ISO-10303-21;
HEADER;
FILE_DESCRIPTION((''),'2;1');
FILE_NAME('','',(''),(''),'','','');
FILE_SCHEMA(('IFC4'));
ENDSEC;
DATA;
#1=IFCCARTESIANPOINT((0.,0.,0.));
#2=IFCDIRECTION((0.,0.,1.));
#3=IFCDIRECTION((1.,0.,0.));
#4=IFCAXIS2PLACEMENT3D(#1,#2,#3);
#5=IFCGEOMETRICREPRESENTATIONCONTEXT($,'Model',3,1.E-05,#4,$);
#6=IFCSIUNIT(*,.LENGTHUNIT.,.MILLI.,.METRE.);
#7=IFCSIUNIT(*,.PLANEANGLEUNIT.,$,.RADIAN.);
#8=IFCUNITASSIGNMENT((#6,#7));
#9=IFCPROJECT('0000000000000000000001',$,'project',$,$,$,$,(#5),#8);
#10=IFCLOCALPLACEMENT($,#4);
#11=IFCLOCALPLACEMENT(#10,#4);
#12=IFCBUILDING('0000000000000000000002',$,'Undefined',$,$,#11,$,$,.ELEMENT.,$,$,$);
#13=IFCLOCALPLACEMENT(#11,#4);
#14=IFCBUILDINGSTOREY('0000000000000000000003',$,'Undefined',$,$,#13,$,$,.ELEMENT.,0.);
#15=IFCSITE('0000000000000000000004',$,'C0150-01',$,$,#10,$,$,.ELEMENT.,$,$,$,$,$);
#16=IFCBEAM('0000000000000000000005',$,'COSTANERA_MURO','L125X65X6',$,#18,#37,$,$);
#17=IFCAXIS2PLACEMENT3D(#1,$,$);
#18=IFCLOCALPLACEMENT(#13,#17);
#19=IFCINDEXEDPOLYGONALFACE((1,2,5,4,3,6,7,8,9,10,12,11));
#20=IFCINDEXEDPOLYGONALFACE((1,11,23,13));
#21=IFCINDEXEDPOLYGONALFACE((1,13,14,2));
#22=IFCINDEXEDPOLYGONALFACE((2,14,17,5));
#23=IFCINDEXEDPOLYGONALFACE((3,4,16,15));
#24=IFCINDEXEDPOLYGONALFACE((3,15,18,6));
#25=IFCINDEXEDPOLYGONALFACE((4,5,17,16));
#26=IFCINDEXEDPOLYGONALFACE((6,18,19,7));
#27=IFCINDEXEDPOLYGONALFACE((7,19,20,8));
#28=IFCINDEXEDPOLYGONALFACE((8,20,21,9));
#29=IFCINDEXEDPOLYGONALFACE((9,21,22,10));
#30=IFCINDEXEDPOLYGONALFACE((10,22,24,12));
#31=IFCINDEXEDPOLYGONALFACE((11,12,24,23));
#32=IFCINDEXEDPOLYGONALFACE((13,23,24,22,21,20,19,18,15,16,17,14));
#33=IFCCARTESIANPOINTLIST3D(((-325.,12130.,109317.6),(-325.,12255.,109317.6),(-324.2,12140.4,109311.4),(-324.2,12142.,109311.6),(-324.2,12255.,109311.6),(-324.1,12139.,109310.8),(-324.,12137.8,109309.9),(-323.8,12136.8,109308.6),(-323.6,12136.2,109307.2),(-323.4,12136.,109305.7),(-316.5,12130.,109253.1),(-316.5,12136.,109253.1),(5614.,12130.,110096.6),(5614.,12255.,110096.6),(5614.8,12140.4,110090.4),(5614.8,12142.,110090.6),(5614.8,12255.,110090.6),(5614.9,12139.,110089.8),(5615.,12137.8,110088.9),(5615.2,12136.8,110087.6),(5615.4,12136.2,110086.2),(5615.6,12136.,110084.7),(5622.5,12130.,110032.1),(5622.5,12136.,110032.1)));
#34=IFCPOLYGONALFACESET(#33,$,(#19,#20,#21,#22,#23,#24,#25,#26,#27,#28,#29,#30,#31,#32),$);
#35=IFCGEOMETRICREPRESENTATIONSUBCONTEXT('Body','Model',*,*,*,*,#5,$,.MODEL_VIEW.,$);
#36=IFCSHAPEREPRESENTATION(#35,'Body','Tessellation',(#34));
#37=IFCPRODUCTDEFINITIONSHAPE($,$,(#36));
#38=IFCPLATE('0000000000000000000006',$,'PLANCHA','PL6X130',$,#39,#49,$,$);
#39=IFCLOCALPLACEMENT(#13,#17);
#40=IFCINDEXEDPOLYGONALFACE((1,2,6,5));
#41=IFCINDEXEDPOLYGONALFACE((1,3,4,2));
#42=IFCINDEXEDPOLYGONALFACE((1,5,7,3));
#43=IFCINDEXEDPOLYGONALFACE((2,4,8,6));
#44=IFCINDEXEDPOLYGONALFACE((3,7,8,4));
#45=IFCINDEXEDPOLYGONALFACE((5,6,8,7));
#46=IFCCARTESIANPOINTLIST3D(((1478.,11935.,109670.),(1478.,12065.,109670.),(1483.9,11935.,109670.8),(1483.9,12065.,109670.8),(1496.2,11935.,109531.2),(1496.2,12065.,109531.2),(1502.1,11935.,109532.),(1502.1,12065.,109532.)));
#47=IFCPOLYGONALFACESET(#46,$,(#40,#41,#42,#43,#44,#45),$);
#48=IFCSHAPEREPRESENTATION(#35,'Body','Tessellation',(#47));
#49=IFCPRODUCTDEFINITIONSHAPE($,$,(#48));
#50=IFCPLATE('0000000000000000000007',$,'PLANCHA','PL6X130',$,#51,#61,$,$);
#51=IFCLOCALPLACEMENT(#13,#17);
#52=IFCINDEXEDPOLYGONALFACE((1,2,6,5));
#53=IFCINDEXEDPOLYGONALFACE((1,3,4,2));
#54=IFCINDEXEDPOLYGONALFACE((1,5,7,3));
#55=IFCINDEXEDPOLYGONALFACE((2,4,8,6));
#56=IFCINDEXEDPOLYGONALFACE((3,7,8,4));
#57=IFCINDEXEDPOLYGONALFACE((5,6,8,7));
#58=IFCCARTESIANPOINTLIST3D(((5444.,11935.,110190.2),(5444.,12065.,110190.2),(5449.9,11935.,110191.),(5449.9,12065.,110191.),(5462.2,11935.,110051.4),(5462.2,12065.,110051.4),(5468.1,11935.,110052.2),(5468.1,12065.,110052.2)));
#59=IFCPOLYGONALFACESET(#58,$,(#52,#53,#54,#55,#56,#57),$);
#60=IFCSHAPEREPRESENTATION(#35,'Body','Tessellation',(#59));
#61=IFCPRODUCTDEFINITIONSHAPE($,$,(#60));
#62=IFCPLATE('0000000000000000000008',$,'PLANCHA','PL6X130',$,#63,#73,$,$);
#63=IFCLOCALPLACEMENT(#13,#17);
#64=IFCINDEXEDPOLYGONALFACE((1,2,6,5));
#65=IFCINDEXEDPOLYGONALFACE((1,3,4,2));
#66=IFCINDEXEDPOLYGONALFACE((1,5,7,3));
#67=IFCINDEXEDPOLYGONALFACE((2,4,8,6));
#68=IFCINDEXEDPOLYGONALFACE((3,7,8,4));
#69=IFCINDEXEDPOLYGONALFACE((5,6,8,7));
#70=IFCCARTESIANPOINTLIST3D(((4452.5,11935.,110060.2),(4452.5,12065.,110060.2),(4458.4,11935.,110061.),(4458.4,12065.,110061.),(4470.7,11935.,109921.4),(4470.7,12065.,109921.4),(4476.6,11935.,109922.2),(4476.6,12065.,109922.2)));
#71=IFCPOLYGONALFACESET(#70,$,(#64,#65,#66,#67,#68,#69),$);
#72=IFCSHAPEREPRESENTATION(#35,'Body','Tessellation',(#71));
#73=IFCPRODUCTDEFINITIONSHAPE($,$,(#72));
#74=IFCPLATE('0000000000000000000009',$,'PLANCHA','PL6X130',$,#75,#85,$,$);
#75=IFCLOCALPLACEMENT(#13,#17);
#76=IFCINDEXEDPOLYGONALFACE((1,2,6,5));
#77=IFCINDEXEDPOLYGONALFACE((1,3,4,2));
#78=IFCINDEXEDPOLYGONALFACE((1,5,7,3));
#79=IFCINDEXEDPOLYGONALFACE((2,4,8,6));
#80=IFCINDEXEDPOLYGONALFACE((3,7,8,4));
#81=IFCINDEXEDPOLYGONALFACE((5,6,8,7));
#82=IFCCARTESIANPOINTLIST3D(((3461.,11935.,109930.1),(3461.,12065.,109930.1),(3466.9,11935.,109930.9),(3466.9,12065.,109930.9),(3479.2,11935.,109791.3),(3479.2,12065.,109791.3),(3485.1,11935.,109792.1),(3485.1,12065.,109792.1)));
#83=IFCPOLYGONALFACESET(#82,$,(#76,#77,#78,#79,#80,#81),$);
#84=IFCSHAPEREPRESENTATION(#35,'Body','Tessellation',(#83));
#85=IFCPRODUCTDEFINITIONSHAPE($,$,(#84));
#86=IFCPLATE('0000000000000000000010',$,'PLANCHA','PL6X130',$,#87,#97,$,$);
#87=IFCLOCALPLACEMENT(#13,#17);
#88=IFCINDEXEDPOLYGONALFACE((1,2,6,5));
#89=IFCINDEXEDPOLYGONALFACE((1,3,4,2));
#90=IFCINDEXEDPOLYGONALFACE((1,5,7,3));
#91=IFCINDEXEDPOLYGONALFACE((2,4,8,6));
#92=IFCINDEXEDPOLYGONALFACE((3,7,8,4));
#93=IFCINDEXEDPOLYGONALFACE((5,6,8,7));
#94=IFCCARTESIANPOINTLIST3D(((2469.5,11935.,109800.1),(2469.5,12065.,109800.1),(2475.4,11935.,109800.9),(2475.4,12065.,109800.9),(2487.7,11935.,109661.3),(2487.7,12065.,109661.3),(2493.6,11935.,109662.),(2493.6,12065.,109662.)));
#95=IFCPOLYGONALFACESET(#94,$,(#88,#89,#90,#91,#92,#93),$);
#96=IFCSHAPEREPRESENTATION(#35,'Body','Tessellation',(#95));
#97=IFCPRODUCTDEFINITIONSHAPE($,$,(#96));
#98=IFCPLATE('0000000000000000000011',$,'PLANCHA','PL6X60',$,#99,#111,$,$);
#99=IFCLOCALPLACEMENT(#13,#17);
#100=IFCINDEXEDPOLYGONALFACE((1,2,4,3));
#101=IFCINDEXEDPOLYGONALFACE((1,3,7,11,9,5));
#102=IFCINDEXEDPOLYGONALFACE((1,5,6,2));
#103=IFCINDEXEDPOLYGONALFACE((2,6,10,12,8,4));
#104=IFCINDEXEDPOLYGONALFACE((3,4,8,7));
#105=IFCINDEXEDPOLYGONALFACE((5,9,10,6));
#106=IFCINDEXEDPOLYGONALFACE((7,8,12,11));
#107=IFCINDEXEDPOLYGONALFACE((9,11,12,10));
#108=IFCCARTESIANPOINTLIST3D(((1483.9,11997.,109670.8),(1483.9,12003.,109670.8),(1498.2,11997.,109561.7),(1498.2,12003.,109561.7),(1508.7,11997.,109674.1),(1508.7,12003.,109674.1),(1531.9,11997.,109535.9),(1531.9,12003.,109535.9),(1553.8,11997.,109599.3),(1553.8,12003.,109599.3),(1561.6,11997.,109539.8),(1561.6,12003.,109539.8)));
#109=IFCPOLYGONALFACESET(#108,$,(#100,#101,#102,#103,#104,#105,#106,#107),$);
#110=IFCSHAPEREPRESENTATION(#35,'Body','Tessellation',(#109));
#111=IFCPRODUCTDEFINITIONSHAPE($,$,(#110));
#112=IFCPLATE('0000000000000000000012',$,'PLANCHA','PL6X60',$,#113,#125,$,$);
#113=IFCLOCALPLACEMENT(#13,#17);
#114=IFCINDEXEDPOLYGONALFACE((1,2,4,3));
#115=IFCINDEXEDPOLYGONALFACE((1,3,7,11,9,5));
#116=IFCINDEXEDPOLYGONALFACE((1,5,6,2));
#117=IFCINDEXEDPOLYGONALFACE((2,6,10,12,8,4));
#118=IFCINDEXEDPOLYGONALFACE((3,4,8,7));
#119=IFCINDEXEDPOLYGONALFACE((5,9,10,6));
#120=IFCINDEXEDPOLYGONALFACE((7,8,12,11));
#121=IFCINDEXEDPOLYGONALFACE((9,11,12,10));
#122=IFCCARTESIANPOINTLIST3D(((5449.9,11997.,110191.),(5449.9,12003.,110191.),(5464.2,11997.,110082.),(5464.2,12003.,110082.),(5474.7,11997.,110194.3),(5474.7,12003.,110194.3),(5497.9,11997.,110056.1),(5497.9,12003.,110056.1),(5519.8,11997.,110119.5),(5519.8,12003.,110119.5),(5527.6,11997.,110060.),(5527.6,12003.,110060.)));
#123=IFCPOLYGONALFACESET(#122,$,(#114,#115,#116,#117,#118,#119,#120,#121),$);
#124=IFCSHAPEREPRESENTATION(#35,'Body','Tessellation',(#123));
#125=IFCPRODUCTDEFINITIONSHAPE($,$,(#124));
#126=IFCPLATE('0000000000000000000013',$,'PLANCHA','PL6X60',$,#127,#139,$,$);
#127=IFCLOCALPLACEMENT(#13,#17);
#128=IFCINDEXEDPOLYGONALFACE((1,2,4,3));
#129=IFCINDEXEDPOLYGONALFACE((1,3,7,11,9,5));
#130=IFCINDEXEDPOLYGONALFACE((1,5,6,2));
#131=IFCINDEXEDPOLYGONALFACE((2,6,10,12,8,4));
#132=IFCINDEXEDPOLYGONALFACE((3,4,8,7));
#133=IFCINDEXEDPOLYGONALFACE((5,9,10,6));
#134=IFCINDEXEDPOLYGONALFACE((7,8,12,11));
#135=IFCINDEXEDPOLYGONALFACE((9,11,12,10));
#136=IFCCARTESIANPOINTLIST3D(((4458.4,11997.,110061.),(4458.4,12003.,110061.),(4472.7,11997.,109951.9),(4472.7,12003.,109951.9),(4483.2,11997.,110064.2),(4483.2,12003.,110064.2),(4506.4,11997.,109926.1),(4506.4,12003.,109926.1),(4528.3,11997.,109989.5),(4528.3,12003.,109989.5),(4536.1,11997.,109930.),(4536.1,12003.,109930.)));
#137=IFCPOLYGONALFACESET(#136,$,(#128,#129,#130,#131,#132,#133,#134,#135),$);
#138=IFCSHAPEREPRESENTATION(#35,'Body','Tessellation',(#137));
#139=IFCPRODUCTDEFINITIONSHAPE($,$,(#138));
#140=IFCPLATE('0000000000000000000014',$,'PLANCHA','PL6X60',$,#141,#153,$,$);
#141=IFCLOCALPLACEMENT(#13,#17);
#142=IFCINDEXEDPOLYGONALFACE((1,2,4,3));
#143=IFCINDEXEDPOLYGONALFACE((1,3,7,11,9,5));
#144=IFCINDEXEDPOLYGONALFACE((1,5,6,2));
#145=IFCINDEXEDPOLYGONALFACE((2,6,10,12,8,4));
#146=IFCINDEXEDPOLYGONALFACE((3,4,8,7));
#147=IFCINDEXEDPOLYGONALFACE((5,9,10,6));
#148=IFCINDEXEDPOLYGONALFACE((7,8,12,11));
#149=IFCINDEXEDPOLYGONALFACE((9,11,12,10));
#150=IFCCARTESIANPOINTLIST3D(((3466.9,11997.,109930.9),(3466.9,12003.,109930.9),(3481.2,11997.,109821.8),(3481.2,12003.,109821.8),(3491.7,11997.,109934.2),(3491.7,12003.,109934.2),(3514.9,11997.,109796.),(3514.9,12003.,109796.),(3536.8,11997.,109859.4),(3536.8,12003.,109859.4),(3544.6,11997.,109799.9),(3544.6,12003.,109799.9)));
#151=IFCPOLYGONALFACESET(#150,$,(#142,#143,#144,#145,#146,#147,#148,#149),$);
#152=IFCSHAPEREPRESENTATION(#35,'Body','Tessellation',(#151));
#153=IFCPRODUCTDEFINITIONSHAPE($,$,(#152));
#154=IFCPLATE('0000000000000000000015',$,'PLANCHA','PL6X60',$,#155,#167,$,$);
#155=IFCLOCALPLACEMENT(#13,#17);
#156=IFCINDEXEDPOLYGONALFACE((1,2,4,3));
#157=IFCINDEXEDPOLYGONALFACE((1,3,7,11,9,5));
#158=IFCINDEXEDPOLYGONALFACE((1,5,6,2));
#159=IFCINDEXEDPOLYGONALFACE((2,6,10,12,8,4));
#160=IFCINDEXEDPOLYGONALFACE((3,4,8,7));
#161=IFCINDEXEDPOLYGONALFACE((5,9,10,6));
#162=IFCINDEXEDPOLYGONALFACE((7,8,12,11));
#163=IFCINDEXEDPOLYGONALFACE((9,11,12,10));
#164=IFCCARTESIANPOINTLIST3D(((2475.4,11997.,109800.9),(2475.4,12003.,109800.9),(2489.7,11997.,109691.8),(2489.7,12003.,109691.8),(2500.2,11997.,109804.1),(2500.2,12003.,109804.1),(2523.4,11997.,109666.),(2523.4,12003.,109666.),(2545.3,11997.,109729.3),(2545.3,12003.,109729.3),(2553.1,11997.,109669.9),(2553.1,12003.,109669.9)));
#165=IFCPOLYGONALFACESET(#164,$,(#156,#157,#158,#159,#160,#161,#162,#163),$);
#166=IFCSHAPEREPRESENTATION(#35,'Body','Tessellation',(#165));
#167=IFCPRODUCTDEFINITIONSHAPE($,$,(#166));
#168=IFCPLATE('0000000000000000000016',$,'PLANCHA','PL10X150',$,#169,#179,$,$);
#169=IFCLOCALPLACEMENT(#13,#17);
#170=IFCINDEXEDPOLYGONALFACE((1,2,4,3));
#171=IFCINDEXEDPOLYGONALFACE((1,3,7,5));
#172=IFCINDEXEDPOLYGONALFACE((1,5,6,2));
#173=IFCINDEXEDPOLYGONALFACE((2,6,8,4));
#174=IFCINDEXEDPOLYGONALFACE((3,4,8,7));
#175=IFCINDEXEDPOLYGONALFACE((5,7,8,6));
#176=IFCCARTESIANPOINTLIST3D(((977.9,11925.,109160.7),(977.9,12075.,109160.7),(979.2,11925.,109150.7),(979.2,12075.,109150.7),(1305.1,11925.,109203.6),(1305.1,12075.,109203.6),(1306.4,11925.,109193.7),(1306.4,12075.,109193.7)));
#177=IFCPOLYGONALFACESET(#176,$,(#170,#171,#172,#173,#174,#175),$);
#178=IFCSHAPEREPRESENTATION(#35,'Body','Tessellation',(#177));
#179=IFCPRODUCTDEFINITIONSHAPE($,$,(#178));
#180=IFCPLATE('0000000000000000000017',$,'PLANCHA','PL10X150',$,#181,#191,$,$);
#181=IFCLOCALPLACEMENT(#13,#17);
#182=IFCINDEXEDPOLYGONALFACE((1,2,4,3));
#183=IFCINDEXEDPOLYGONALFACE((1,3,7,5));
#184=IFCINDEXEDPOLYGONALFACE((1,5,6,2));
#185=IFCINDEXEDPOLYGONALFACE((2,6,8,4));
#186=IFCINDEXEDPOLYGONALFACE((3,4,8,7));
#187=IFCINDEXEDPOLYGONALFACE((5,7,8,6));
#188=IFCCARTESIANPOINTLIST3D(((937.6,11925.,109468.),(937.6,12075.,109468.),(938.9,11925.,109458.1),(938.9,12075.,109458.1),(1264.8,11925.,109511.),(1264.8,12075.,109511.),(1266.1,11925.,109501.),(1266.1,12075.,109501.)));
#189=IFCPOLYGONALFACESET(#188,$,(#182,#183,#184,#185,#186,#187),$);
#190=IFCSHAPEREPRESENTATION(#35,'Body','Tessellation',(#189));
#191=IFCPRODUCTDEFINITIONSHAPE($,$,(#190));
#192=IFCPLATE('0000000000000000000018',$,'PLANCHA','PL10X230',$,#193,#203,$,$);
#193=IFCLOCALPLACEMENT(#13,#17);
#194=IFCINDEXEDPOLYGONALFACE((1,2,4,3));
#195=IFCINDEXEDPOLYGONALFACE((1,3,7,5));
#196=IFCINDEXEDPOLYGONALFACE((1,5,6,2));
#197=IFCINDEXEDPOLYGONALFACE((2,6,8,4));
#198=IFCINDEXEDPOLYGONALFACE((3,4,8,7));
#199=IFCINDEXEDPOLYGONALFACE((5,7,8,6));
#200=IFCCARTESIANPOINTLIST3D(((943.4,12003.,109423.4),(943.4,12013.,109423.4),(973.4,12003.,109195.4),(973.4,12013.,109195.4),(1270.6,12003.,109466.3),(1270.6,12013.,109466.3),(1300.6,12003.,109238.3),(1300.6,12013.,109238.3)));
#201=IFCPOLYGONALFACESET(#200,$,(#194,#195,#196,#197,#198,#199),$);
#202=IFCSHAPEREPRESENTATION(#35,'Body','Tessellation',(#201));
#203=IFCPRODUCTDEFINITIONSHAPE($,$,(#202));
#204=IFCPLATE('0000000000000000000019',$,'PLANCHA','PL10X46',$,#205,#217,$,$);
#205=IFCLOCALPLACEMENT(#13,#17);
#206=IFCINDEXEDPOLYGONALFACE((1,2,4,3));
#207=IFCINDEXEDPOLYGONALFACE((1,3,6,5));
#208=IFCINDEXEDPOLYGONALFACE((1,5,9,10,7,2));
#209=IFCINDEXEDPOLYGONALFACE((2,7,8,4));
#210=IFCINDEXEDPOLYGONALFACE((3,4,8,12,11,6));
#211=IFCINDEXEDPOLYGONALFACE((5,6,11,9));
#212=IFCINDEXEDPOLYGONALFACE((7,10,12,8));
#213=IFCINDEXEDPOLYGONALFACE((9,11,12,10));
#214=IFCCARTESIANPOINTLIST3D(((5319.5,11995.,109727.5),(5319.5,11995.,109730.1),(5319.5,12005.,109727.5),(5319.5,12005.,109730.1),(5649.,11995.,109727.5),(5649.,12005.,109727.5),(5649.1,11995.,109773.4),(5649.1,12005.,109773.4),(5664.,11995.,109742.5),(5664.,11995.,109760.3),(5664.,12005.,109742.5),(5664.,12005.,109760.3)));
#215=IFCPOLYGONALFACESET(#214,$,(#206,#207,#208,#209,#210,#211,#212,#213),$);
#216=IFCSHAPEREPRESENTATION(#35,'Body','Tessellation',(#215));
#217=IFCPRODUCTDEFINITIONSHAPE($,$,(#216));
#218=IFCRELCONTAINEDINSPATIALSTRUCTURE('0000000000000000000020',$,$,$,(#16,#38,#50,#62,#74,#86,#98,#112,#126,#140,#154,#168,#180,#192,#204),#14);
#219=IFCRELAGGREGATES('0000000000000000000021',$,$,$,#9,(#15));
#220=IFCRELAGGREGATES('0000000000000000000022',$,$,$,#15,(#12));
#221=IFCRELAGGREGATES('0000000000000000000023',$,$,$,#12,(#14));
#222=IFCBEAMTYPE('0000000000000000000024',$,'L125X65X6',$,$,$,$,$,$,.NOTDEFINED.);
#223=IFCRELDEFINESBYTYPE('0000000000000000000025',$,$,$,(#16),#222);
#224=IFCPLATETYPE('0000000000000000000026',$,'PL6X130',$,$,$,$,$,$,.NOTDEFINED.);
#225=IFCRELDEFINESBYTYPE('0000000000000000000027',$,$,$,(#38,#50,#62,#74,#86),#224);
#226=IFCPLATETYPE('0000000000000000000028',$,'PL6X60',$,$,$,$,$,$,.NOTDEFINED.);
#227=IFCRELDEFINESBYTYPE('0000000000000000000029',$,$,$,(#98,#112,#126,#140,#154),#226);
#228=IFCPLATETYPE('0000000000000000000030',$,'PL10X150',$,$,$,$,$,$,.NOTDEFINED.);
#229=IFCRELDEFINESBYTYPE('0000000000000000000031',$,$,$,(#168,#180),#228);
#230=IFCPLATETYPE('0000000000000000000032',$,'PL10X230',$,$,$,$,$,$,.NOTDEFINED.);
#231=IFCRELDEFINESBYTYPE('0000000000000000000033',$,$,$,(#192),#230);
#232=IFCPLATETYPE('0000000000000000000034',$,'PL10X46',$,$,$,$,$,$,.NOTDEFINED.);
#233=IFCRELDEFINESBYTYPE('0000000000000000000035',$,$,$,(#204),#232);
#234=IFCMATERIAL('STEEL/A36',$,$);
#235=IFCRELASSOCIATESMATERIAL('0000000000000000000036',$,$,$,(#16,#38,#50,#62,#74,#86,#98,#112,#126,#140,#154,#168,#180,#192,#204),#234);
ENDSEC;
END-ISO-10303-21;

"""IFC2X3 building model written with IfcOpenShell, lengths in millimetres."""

from ifc_helpers import new_model, si_unit, frame, origin_with_axes, origin_2d_with_axis, place, context, subcontext, project, spatial, polyline, l_section, outline, extrude, material, type_object, element, save


model = new_model("IFC2X3")

# Units and contexts
model_context = context("Model", 3, precision=1e-05, world=origin_with_axes())
body_context = subcontext(model_context, "Body", "Model", "MODEL_VIEW")
ifc_project = project(units=[si_unit("LENGTHUNIT", "METRE", prefix="MILLI"), si_unit("PLANEANGLEUNIT", "RADIAN")], contexts=[model_context])

# Site, building, storey
site_placement = place(None, origin_with_axes())
site = spatial("IfcSite", under=ifc_project, at=site_placement, Name="C0150-01", CompositionType="ELEMENT")
building_placement = place(site_placement, origin_with_axes())
building = spatial("IfcBuilding", under=site, at=building_placement, Name="Undefined", CompositionType="ELEMENT")
storey_placement = place(building_placement, origin_with_axes())
storey = spatial("IfcBuildingStorey", under=building, at=storey_placement, Name="Undefined", CompositionType="ELEMENT", Elevation=0.0)

# Beam
ifc_material_1 = material(Name="STEEL/A36")
beam_type_1 = type_object("IfcBeamType", Name="L125X65X6", PredefinedType="NOTDEFINED")
beam_1_placement = place(storey_placement, frame((5618.2, 12192.5, 110064.3), z_axis=(0.0, 1.0, 0.0), x_axis=(-0.991507, 0.0, -0.130054)))
element("IfcBeam", 1, at=beam_1_placement, inside=storey, type_object=beam_type_1, material=ifc_material_1, Name="COSTANERA_MURO", Description="L125X65X6", context=body_context, shape_type="SweptSolid", body=[
    extrude(l_section(Depth=125.0, Width=65.0, Thickness=6.0, FilletRadius=6.0, at=origin_2d_with_axis()), frame((5989.9, 0.0, 0.0), z_axis=(-1.0, 0.0, 0.0), x_axis=(0.0, -1.0, 0.0)), (0.0, 0.0, 1.0), 5989.9),
])

# Plates
plate_type_1 = type_object("IfcPlateType", Name="PL6X130", PredefinedType="NOTDEFINED")
for number, where, z_axis, x_axis, name in (
    (2, (1499.1, 12065.0, 109531.6), (-0.991507, 0.0, -0.130054), (0.0, -1.0, 0.0), "PLANCHA"),
    (3, (5465.2, 12065.0, 110051.8), (-0.991507, 0.0, -0.130054), (0.0, -1.0, 0.0), "PLANCHA"),
    (4, (4473.7, 12065.0, 109921.8), (-0.991507, 0.0, -0.130054), (0.0, -1.0, 0.0), "PLANCHA"),
    (5, (3482.2, 12065.0, 109791.7), (-0.991507, 0.0, -0.130054), (0.0, -1.0, 0.0), "PLANCHA"),
    (6, (2490.6, 12065.0, 109661.7), (-0.991507, 0.0, -0.130054), (0.0, -1.0, 0.0), "PLANCHA"),
):
    element("IfcPlate", number, at=place(storey_placement, frame(where, z_axis=z_axis, x_axis=x_axis)), inside=storey, type_object=plate_type_1, material=ifc_material_1, Name=name, Description="PL6X130", context=body_context, shape_type="SweptSolid", body=[
        extrude(outline(polyline([(0.0, 0.0), (130.0, 0.0), (130.0, 140.0), (0.0, 140.0), (0.0, 0.0)])), frame((0.0, 0.0, -3.0), z_axis=(0.0, 0.0, 1.0), x_axis=(1.0, 0.0, 0.0)), (0.0, 0.0, 1.0), 6.0),
    ])
plate_type_2 = type_object("IfcPlateType", Name="PL6X60", PredefinedType="NOTDEFINED")
for number, where, z_axis, x_axis, name in (
    (7, (1508.7, 12000.0, 109674.1), (0.0, -1.0, 0.0), (-0.991507, 0.0, -0.130054), "PLANCHA"),
    (8, (5474.7, 12000.0, 110194.3), (0.0, -1.0, 0.0), (-0.991507, 0.0, -0.130054), "PLANCHA"),
    (9, (4483.2, 12000.0, 110064.2), (0.0, -1.0, 0.0), (-0.991507, 0.0, -0.130054), "PLANCHA"),
    (10, (3491.7, 12000.0, 109934.2), (0.0, -1.0, 0.0), (-0.991507, 0.0, -0.130054), "PLANCHA"),
    (11, (2500.2, 12000.0, 109804.1), (0.0, -1.0, 0.0), (-0.991507, 0.0, -0.130054), "PLANCHA"),
):
    element("IfcPlate", number, at=place(storey_placement, frame(where, z_axis=z_axis, x_axis=x_axis)), inside=storey, type_object=plate_type_2, material=ifc_material_1, Name=name, Description="PL6X60", context=body_context, shape_type="SweptSolid", body=[
        extrude(outline(polyline([(0.0, 0.0), (25.0, 0.0), (25.0, 110.0), (-5.0, 140.0), (-35.0, 140.0), (-35.0, 80.0), (0.0, 0.0)])), frame((0.0, 0.0, -3.0), z_axis=(0.0, 0.0, 1.0), x_axis=(1.0, 0.0, 0.0)), (0.0, 0.0, 1.0), 6.0),
    ])
plate_type_3 = type_object("IfcPlateType", Name="PL10X150", PredefinedType="NOTDEFINED")
for number, where, z_axis, x_axis, name in (
    (12, (1305.8, 12075.0, 109198.6), (-0.130054, 0.0, 0.991507), (-0.991507, 0.0, -0.130054), "PLANCHA"),
    (13, (1265.4, 12075.0, 109506.0), (-0.130054, 0.0, 0.991507), (-0.991507, 0.0, -0.130054), "PLANCHA"),
):
    element("IfcPlate", number, at=place(storey_placement, frame(where, z_axis=z_axis, x_axis=x_axis)), inside=storey, type_object=plate_type_3, material=ifc_material_1, Name=name, Description="PL10X150", context=body_context, shape_type="SweptSolid", body=[
        extrude(outline(polyline([(0.0, 0.0), (330.0, 0.0), (330.0, 150.0), (0.0, 150.0), (0.0, 0.0)])), frame((0.0, 0.0, -5.0), z_axis=(0.0, 0.0, 1.0), x_axis=(1.0, 0.0, 0.0)), (0.0, 0.0, 1.0), 10.0),
    ])
plate_type_4 = type_object("IfcPlateType", Name="PL10X230", PredefinedType="NOTDEFINED")
plate_1_placement = place(storey_placement, frame((943.4, 12008.0, 109423.4), z_axis=(0.0, -1.0, 0.0), x_axis=(0.130054, 0.0, -0.991507)))
element("IfcPlate", 14, at=plate_1_placement, inside=storey, type_object=plate_type_4, material=ifc_material_1, Name="PLANCHA", Description="PL10X230", context=body_context, shape_type="SweptSolid", body=[
    extrude(outline(polyline([(0.0, 0.0), (230.0, 0.0), (230.0, 330.0), (0.0, 330.0), (0.0, 0.0)])), frame((0.0, 0.0, -5.0), z_axis=(0.0, 0.0, 1.0), x_axis=(1.0, 0.0, 0.0)), (0.0, 0.0, 1.0), 10.0),
])
plate_type_5 = type_object("IfcPlateType", Name="PL10X46", PredefinedType="NOTDEFINED")
plate_2_placement = place(storey_placement, frame((5664.0, 12000.0, 109727.5), z_axis=(0.0, -1.0, 0.0), x_axis=(0.0, 0.0, 1.0)))
element("IfcPlate", 15, at=plate_2_placement, inside=storey, type_object=plate_type_5, material=ifc_material_1, Name="PLANCHA", Description="PL10X46", context=body_context, shape_type="SweptSolid", body=[
    extrude(outline(polyline([(0.0, 15.0), (15.0, 0.0), (32.8, 0.0), (45.9, 14.9), (2.6, 344.5), (0.0, 344.5), (0.0, 15.0)])), frame((0.0, 0.0, -5.0), z_axis=(0.0, 0.0, 1.0), x_axis=(1.0, 0.0, 0.0)), (0.0, 0.0, 1.0), 10.0),
])

save(model, "model.ifc")
